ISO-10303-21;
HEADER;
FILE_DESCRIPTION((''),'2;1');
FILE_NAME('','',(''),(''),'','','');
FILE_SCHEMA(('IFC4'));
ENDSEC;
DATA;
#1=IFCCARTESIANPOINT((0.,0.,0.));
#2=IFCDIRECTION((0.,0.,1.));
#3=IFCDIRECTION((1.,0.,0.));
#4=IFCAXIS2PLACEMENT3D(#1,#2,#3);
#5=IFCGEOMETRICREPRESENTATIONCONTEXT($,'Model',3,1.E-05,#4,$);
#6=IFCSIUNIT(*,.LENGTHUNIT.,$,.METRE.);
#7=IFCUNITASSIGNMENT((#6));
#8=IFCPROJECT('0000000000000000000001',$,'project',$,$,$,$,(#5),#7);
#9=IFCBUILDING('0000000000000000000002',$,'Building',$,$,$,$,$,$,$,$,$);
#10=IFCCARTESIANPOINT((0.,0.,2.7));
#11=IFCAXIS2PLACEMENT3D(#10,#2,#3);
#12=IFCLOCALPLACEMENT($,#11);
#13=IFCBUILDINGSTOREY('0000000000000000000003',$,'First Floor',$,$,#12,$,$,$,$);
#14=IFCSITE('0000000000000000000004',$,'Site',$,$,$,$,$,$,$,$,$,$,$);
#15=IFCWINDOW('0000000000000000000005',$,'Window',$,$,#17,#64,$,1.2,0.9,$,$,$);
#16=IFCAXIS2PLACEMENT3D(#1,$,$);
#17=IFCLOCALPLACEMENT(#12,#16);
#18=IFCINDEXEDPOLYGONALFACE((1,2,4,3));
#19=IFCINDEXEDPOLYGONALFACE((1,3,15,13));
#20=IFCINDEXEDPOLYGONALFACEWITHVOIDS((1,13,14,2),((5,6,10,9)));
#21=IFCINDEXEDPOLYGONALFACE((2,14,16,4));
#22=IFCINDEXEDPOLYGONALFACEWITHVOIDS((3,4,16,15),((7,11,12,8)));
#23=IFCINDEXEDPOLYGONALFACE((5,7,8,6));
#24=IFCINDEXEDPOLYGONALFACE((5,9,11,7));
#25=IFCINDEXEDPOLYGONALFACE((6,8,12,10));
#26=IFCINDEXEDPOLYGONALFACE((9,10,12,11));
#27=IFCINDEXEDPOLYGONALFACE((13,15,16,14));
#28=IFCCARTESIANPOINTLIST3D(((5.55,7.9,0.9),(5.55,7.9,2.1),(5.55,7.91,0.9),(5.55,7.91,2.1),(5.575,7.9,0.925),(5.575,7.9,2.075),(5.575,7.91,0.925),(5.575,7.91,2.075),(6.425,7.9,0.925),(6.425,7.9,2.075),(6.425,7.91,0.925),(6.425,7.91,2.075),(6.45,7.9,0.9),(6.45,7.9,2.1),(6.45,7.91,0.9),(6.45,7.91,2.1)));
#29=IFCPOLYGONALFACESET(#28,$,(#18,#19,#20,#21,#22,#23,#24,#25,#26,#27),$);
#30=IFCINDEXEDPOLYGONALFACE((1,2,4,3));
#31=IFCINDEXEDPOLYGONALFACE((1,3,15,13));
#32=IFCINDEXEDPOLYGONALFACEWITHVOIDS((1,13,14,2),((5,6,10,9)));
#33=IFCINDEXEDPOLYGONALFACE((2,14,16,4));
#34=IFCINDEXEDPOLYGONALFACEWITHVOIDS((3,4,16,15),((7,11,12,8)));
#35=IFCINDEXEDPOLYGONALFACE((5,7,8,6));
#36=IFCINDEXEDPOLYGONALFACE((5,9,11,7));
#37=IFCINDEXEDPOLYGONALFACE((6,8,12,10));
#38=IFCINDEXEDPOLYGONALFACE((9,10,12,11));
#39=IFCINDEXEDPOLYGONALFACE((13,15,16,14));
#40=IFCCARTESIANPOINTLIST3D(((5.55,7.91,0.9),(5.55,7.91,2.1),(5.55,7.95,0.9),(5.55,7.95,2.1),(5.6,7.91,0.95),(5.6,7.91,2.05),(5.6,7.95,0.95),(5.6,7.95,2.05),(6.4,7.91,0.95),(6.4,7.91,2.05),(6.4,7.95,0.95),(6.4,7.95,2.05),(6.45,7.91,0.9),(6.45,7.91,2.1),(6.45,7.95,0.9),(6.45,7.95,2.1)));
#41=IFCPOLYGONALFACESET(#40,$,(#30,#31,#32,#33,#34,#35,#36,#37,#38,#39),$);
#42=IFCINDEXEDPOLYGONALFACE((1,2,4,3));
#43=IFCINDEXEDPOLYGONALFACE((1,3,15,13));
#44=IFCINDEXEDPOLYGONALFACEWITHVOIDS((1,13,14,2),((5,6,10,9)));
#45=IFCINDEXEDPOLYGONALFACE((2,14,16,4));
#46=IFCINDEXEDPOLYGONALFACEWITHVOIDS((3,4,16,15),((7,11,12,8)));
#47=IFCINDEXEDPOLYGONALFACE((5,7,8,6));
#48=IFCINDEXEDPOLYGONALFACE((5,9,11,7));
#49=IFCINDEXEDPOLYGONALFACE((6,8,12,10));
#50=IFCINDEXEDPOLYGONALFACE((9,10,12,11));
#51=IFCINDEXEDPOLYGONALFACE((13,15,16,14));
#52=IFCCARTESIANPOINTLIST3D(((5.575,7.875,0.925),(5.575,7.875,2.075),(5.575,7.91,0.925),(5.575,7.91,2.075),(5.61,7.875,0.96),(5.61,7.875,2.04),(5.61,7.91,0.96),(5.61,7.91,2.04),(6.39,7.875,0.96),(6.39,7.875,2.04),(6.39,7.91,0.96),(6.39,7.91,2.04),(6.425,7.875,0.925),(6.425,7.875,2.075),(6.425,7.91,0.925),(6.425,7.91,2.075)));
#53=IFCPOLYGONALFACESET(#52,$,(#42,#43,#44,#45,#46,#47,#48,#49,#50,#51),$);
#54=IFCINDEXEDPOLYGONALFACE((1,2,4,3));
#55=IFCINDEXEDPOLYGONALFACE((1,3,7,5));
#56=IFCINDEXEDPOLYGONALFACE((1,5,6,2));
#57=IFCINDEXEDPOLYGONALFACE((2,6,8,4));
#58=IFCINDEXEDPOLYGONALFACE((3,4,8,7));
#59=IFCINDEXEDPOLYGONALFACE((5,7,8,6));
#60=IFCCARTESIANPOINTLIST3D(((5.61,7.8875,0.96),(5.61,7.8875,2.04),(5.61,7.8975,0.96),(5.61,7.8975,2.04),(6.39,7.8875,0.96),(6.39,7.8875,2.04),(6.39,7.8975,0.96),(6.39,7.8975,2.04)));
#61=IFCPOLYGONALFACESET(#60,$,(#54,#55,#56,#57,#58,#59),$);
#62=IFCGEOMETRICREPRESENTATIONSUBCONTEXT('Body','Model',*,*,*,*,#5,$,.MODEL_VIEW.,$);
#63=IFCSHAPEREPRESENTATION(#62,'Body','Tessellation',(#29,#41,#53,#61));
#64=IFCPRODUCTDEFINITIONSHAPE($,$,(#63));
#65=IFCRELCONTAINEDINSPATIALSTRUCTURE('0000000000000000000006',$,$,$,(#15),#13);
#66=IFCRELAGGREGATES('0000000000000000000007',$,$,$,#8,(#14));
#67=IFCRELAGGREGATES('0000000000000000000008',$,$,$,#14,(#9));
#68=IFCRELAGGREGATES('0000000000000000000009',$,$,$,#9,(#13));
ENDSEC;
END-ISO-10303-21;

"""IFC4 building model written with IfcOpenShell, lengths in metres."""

from ifc_helpers import new_model, si_unit, frame, origin_with_axes, place, context, subcontext, project, spatial, line, indexed_curve, outline, extrude, element, save


model = new_model("IFC4")

# Units and contexts
model_context = context("Model", 3, precision=1e-05, world=origin_with_axes())
body_context = subcontext(model_context, "Body", "Model", "MODEL_VIEW")
ifc_project = project(units=[si_unit("LENGTHUNIT", "METRE")], contexts=[model_context])

# Site, building, storey
site = spatial("IfcSite", under=ifc_project, Name="Site")
building = spatial("IfcBuilding", under=site, Name="Building")
storey_placement = place(None, frame((0.0, 0.0, 2.7), z_axis=(0.0, 0.0, 1.0), x_axis=(1.0, 0.0, 0.0)))
storey = spatial("IfcBuildingStorey", under=building, at=storey_placement, Name="First Floor")

# Window
window_1_placement = place(storey_placement, frame((6.45, 8.0, 0.9), z_axis=(0.0, 0.0, 1.0), x_axis=(-1.0, 0.0, 0.0)))
element("IfcWindow", 1, at=window_1_placement, inside=storey, Name="Window", OverallHeight=1.2, OverallWidth=0.9, context=body_context, shape_type="SweptSolid", body=[
    extrude(outline(indexed_curve([(0.0, 0.0), (0.9, 0.0), (0.9, 1.2), (0.0, 1.2)], segments=[line(1, 2, 3, 4, 1)]), holes=[indexed_curve([(0.025, 0.025), (0.875, 0.025), (0.875, 1.175), (0.025, 1.175)], segments=[line(1, 2, 3, 4, 1)])]), frame((0.0, 0.09, 0.0), z_axis=(0.0, -1.0, 0.0), x_axis=(1.0, 0.0, 0.0)), (0.0, 0.0, -1.0), 0.01),
    extrude(outline(indexed_curve([(0.0, 0.0), (0.9, 0.0), (0.9, 1.2), (0.0, 1.2)], segments=[line(1, 2, 3, 4, 1)]), holes=[indexed_curve([(0.05, 0.05), (0.85, 0.05), (0.85, 1.15), (0.05, 1.15)], segments=[line(1, 2, 3, 4, 1)])]), frame((0.0, 0.05, 0.0), z_axis=(0.0, -1.0, 0.0), x_axis=(1.0, 0.0, 0.0)), (0.0, 0.0, -1.0), 0.04),
    extrude(outline(indexed_curve([(0.0, 0.0), (0.85, 0.0), (0.85, 1.15), (0.0, 1.15)], segments=[line(1, 2, 3, 4, 1)]), holes=[indexed_curve([(0.035, 0.035), (0.815, 0.035), (0.815, 1.115), (0.035, 1.115)], segments=[line(1, 2, 3, 4, 1)])]), frame((0.025, 0.09, 0.025), z_axis=(0.0, -1.0, 0.0), x_axis=(1.0, 0.0, 0.0)), (0.0, 0.0, -1.0), 0.035),
    extrude(outline(indexed_curve([(0.035, 0.035), (0.815, 0.035), (0.815, 1.115), (0.035, 1.115)], segments=[line(1, 2, 3, 4, 1)])), frame((0.025, 0.1025, 0.025), z_axis=(0.0, -1.0, 0.0), x_axis=(1.0, 0.0, 0.0)), (0.0, 0.0, -1.0), 0.01),
])

save(model, "model.ifc")
